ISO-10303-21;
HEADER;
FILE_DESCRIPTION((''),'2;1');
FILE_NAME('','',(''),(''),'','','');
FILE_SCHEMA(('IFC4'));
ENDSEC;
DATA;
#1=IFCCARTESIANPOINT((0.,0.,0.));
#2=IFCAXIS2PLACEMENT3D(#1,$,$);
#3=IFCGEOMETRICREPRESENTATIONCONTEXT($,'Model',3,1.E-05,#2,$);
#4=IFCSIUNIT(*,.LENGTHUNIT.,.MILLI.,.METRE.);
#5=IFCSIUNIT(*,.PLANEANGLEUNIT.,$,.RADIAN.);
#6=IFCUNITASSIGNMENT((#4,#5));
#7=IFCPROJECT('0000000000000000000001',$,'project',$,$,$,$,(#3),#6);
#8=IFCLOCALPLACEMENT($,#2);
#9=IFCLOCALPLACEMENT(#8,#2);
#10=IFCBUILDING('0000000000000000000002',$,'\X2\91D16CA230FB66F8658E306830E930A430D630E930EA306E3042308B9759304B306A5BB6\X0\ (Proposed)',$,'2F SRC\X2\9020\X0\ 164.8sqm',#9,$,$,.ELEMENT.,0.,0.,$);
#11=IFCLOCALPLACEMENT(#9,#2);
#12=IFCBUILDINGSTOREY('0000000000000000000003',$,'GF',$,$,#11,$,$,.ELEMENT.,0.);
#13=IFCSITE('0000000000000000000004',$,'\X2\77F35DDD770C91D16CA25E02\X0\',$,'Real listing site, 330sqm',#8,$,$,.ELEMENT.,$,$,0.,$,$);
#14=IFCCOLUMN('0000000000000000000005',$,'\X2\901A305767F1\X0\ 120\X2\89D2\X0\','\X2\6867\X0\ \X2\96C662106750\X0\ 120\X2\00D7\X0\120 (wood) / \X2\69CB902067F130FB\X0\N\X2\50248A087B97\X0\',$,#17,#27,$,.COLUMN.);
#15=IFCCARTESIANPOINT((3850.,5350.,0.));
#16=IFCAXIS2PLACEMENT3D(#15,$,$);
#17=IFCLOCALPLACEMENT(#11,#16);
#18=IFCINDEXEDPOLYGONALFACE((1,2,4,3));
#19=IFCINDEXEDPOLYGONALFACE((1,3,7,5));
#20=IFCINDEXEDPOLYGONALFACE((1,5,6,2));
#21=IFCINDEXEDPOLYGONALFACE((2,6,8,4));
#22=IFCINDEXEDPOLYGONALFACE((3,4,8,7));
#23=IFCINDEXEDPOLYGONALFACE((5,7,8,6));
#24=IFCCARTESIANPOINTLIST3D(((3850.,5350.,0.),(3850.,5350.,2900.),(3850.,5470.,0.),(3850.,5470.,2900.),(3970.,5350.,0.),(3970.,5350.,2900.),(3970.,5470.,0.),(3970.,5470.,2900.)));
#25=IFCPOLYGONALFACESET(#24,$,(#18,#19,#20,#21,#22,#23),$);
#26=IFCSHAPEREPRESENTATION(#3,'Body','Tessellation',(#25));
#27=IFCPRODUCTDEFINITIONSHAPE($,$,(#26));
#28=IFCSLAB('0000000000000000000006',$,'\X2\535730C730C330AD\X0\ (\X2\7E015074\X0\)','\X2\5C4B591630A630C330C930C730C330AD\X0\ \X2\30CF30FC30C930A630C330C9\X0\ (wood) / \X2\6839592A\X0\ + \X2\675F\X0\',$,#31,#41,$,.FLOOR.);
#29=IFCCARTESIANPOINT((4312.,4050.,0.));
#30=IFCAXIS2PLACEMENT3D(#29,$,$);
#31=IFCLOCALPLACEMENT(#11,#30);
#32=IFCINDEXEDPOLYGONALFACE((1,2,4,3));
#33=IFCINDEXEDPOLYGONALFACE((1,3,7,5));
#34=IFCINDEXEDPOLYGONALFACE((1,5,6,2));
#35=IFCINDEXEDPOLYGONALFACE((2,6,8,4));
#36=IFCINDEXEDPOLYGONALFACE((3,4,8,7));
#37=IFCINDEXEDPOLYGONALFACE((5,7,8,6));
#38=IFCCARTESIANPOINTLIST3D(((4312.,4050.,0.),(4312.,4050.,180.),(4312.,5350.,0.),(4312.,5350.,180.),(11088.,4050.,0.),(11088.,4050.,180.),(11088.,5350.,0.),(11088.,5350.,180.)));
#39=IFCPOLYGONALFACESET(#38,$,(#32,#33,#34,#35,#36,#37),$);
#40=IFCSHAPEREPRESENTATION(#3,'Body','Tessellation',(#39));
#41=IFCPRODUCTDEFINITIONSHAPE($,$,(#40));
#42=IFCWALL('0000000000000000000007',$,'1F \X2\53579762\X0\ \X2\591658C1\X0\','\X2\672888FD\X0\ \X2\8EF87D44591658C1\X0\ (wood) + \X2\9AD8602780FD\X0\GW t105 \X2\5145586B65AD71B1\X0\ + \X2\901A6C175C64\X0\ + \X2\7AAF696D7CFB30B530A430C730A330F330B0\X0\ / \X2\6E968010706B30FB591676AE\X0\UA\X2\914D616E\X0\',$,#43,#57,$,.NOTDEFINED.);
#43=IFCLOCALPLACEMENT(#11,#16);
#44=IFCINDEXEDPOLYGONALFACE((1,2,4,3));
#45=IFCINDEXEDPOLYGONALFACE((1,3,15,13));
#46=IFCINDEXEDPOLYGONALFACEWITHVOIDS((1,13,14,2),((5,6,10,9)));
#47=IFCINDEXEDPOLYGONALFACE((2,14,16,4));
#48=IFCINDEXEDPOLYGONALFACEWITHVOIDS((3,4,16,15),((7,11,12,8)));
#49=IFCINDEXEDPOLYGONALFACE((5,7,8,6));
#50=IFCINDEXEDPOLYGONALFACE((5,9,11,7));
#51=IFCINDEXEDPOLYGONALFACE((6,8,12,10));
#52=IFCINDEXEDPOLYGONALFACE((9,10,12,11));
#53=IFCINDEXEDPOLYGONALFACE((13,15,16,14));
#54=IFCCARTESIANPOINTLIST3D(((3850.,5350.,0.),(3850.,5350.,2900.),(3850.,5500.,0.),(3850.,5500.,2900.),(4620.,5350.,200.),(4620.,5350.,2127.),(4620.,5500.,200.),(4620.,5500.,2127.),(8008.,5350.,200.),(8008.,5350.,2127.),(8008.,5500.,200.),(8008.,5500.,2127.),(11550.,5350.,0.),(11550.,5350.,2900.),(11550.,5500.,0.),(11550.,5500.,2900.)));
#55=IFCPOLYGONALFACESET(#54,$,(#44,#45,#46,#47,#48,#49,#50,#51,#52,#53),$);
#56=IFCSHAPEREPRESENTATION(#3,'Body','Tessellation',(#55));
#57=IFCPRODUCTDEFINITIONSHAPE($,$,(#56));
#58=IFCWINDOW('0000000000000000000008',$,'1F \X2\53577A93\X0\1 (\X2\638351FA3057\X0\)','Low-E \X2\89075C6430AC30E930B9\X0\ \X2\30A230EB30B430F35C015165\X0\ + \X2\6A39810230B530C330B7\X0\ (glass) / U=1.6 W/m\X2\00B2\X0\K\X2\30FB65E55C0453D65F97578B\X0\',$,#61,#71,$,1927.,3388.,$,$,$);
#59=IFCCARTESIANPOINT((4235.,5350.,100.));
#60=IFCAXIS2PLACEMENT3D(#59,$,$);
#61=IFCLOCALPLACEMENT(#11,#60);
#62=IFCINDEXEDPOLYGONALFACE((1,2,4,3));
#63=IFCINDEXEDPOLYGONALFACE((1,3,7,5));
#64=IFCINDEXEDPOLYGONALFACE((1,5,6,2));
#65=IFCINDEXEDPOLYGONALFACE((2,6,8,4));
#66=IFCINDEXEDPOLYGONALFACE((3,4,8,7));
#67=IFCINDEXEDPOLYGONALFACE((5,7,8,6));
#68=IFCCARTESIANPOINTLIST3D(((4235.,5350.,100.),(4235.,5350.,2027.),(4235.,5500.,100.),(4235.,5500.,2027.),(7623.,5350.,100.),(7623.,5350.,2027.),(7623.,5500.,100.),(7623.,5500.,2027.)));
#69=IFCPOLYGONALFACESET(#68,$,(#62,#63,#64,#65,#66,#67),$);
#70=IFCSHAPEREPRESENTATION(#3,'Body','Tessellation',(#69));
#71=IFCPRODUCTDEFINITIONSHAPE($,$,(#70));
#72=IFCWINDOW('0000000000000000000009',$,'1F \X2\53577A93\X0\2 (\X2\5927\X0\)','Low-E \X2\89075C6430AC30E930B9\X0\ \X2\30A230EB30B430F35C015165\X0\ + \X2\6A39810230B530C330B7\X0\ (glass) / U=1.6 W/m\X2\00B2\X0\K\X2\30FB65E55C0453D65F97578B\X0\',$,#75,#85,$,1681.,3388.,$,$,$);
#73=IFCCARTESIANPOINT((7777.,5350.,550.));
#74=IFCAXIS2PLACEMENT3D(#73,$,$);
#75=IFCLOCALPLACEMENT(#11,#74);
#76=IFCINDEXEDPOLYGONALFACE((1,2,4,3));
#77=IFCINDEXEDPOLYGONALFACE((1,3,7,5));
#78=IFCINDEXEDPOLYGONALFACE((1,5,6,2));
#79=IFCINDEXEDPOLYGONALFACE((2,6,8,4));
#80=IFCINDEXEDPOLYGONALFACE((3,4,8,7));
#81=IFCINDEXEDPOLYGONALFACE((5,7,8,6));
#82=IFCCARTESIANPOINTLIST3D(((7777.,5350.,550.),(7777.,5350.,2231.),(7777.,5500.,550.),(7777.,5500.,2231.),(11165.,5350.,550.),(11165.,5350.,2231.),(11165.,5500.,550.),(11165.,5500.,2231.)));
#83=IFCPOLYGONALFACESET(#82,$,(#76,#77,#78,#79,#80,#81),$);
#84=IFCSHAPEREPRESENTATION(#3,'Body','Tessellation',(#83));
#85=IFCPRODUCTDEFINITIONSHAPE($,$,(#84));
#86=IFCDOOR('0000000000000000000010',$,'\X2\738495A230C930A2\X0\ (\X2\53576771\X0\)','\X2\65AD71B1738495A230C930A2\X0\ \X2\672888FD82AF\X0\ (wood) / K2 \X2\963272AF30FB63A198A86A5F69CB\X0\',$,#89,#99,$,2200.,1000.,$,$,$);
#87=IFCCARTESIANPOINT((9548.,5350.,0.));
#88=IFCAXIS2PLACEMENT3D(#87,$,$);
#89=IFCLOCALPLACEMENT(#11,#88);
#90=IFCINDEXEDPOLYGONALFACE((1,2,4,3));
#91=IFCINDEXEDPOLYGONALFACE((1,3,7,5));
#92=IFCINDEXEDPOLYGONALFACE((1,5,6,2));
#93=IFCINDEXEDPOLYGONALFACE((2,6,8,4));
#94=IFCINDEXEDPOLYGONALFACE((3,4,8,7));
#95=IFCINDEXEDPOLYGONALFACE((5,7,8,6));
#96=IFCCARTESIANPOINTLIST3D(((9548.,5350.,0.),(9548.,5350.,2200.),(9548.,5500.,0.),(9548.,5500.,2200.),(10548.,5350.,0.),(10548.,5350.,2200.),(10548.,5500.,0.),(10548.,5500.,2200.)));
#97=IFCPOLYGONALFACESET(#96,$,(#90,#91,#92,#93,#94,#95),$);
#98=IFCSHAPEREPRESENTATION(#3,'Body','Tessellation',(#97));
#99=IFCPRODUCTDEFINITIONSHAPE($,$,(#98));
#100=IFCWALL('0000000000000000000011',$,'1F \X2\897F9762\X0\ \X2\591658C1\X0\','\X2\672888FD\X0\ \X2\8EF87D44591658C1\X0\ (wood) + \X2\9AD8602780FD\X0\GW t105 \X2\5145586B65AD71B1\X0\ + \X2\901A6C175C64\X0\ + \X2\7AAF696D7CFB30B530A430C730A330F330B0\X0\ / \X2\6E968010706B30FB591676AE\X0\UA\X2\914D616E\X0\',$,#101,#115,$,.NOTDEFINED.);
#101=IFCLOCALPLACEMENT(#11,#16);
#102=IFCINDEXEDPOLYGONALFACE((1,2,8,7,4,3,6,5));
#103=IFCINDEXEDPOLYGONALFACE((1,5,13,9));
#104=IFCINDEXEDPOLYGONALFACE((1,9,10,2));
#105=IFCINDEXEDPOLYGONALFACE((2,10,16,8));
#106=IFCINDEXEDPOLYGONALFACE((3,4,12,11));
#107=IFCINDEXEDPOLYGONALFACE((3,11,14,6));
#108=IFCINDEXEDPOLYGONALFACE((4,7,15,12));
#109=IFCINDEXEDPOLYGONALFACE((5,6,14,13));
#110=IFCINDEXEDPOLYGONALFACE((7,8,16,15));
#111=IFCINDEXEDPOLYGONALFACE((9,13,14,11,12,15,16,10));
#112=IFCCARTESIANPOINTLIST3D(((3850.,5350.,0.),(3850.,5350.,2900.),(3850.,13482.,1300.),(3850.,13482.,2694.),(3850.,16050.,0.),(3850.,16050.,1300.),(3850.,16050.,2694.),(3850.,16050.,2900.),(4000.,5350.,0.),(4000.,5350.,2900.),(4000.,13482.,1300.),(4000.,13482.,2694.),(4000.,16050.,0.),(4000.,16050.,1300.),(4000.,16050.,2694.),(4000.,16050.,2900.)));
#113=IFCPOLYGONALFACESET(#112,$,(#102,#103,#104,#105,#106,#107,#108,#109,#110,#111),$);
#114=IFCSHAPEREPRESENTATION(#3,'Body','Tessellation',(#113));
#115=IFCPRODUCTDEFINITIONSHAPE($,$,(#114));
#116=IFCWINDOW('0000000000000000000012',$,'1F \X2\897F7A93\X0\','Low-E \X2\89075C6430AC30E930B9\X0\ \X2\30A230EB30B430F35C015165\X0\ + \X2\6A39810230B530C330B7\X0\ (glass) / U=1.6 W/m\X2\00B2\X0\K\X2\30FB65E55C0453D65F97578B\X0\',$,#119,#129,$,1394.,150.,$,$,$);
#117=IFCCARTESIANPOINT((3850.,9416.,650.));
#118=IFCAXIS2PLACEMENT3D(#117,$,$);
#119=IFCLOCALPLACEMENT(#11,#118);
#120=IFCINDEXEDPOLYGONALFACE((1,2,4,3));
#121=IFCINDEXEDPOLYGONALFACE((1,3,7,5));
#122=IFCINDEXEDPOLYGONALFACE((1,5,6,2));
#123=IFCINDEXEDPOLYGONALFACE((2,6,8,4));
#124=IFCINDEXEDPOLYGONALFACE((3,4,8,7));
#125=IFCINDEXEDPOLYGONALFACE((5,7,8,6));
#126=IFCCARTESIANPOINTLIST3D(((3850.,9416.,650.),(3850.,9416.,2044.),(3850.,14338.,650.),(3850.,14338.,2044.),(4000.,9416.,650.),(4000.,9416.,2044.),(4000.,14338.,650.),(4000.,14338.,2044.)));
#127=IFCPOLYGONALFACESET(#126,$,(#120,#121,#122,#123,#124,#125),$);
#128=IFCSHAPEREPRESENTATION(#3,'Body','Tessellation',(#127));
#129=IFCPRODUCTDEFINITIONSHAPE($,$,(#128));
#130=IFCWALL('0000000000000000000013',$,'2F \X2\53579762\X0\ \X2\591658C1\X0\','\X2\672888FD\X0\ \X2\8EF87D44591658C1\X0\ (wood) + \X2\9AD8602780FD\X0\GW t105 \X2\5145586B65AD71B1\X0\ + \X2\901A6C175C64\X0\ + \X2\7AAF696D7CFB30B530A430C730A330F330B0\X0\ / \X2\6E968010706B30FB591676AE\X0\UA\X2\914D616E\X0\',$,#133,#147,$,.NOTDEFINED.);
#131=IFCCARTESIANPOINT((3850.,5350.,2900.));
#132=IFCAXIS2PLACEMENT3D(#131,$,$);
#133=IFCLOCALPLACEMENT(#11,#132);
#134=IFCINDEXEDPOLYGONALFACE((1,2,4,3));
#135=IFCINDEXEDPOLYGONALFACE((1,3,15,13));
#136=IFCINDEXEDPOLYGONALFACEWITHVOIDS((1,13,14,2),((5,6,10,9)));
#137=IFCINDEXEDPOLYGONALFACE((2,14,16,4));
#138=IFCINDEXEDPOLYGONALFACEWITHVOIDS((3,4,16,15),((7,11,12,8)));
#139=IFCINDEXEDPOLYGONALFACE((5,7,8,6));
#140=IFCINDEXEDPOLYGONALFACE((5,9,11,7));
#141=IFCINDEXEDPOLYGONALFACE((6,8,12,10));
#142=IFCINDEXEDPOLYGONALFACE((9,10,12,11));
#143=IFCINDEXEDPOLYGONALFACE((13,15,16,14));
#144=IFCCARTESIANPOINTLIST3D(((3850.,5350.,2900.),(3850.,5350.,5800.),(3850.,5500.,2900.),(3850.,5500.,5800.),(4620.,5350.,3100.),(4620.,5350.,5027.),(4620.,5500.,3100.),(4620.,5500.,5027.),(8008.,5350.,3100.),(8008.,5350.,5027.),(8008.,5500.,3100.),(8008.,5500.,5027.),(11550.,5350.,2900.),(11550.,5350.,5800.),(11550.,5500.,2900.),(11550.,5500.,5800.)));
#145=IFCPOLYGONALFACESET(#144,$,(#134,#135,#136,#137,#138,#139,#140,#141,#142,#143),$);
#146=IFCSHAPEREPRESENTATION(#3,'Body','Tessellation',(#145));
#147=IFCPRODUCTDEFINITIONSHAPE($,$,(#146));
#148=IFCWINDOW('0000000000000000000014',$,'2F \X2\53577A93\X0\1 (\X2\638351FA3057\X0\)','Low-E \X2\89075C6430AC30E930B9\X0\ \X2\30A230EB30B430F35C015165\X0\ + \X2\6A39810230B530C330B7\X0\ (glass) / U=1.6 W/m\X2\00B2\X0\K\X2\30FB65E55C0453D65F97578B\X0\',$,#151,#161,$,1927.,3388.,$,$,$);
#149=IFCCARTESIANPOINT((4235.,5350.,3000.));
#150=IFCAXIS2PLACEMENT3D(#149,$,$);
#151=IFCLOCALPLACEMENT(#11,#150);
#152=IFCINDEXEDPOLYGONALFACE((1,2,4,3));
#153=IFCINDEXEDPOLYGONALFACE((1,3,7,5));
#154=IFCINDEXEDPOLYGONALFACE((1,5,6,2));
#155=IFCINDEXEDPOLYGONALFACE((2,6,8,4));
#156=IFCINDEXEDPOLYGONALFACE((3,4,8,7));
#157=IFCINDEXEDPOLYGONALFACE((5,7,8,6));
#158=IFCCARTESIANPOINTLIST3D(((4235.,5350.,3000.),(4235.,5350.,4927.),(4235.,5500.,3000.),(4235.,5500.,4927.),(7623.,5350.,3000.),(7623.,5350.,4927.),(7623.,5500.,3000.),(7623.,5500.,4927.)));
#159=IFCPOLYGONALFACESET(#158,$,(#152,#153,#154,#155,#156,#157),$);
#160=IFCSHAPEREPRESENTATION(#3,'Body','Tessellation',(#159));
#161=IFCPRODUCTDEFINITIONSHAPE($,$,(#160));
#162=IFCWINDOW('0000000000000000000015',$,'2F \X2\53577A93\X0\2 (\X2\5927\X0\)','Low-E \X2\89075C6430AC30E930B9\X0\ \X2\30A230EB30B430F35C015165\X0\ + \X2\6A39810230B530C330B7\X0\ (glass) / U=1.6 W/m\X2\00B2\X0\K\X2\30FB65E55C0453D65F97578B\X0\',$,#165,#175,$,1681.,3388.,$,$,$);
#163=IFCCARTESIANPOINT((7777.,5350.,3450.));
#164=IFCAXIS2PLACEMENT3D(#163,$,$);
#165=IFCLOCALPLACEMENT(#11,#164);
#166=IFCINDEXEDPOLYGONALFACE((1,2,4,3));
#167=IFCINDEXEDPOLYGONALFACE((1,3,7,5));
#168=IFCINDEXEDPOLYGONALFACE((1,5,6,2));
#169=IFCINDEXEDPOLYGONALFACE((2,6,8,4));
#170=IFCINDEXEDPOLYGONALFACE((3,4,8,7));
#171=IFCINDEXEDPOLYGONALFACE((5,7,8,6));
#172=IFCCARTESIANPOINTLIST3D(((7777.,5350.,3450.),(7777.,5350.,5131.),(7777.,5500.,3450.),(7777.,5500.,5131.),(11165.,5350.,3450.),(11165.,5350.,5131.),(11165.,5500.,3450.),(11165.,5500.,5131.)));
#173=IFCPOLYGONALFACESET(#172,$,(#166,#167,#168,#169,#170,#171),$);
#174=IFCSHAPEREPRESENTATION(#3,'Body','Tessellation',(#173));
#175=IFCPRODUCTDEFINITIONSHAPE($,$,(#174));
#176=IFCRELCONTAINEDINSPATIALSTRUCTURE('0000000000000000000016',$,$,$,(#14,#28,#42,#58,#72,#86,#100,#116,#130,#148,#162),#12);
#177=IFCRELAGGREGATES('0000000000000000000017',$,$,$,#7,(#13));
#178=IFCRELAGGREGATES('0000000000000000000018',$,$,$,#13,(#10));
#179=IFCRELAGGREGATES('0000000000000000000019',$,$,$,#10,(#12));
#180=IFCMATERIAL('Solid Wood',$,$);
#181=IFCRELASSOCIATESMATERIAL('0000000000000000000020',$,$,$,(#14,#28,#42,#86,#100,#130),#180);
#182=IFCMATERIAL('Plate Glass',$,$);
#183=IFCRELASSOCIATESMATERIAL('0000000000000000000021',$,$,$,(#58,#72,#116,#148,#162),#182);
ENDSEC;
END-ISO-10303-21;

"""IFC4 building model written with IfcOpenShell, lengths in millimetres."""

from ifc_helpers import new_model, si_unit, frame, frame_2d, origin, place, context, project, spatial, rectangle, extrude, material, element, fill, save


model = new_model("IFC4")

# Units and contexts
model_context = context("Model", 3, precision=1e-05, world=origin())
ifc_project = project(units=[si_unit("LENGTHUNIT", "METRE", prefix="MILLI"), si_unit("PLANEANGLEUNIT", "RADIAN")], contexts=[model_context])

# Site, building, storey
site_placement = place(None, origin())
site = spatial("IfcSite", under=ifc_project, at=site_placement, Name="石川県金沢市", ObjectType="Real listing site, 330sqm", CompositionType="ELEMENT", RefElevation=0.0)
building_placement = place(site_placement, origin())
building = spatial("IfcBuilding", under=site, at=building_placement, Name="金沢・書斎とライブラリのある静かな家 (Proposed)", ObjectType="2F SRC造 164.8sqm", CompositionType="ELEMENT", ElevationOfRefHeight=0.0, ElevationOfTerrain=0.0)
storey_placement = place(building_placement, origin())
storey = spatial("IfcBuildingStorey", under=building, at=storey_placement, Name="GF", CompositionType="ELEMENT", Elevation=0.0)

# Column
ifc_material_1 = material(Name="Solid Wood")
column_placement = place(storey_placement, frame((3850.0, 5350.0, 0.0)))
element("IfcColumn", 1, at=column_placement, inside=storey, material=ifc_material_1, Name="通し柱 120角", Description="桧 集成材 120×120 (wood) / 構造柱・N値計算", PredefinedType="COLUMN", context=model_context, shape_type="SweptSolid", body=[
    extrude(rectangle(XDim=120.0, YDim=120.0, at=frame_2d((60.0, 60.0))), frame((3850.0, 5350.0, 0.0)), (0.0, 0.0, 1.0), 2900.0),
])

# Slab
slab_1_placement = place(storey_placement, frame((4312.0, 4050.0, 0.0)))
element("IfcSlab", 2, at=slab_1_placement, inside=storey, material=ifc_material_1, Name="南デッキ (縁側)", Description="屋外ウッドデッキ ハードウッド (wood) / 根太 + 束", PredefinedType="FLOOR", context=model_context, shape_type="SweptSolid", body=[
    extrude(rectangle(XDim=6776.0, YDim=1300.0, at=frame_2d((3388.0, 650.0))), frame((4312.0, 4050.0, 0.0)), (0.0, 0.0, 1.0), 180.0),
])

# Wall, openings, windows, door
wall_1_placement = place(storey_placement, frame((3850.0, 5350.0, 0.0)))
wall_1 = element("IfcWall", 3, at=wall_1_placement, inside=storey, material=ifc_material_1, Name="1F 南面 外壁", Description="木製 軸組外壁 (wood) + 高性能GW t105 充填断熱 + 通気層 + 窯業系サイディング / 準耐火・外皮UA配慮", PredefinedType="NOTDEFINED", context=model_context, shape_type="SweptSolid", body=[
    extrude(rectangle(XDim=7700.0, YDim=150.0, at=frame_2d((3850.0, 75.0))), frame((3850.0, 5350.0, 0.0)), (0.0, 0.0, 1.0), 2900.0),
])
opening_1_placement = place(storey_placement, frame((4235.0, 5350.0, 100.0)))
opening_1 = element("IfcOpeningElement", 4, at=opening_1_placement, cuts=wall_1, PredefinedType="NOTDEFINED", context=model_context, shape_type="SweptSolid", body=[
    extrude(rectangle(XDim=3388.0, YDim=150.0, at=frame_2d((1694.0, 75.0))), frame((4235.0, 5350.0, 100.0)), (0.0, 0.0, 1.0), 1927.0),
])
opening_2_placement = place(storey_placement, frame((7777.0, 5350.0, 550.0)))
opening_2 = element("IfcOpeningElement", 5, at=opening_2_placement, cuts=wall_1, PredefinedType="NOTDEFINED", context=model_context, shape_type="SweptSolid", body=[
    extrude(rectangle(XDim=3388.0, YDim=150.0, at=frame_2d((1694.0, 75.0))), frame((7777.0, 5350.0, 550.0)), (0.0, 0.0, 1.0), 1681.0),
])
opening_3_placement = place(storey_placement, frame((9548.0, 5350.0, 0.0)))
opening_3 = element("IfcOpeningElement", 6, at=opening_3_placement, cuts=wall_1, PredefinedType="NOTDEFINED", context=model_context, shape_type="SweptSolid", body=[
    extrude(rectangle(XDim=1000.0, YDim=150.0, at=frame_2d((500.0, 75.0))), frame((9548.0, 5350.0, 0.0)), (0.0, 0.0, 1.0), 2200.0),
])
ifc_material_2 = material(Name="Plate Glass")
window_1_placement = place(storey_placement, frame((4235.0, 5350.0, 100.0)))
window_1 = element("IfcWindow", 7, at=window_1_placement, inside=storey, material=ifc_material_2, Name="1F 南窓1 (掃出し)", Description="Low-E 複層ガラス アルゴン封入 + 樹脂サッシ (glass) / U=1.6 W/m²K・日射取得型", OverallHeight=1927.0, OverallWidth=3388.0, context=model_context, shape_type="SweptSolid", body=[
    extrude(rectangle(XDim=3388.0, YDim=150.0, at=frame_2d((1694.0, 75.0))), frame((4235.0, 5350.0, 100.0)), (0.0, 0.0, 1.0), 1927.0),
])
fill(opening_1, window_1)
window_2_placement = place(storey_placement, frame((7777.0, 5350.0, 550.0)))
window_2 = element("IfcWindow", 8, at=window_2_placement, inside=storey, material=ifc_material_2, Name="1F 南窓2 (大)", Description="Low-E 複層ガラス アルゴン封入 + 樹脂サッシ (glass) / U=1.6 W/m²K・日射取得型", OverallHeight=1681.0, OverallWidth=3388.0, context=model_context, shape_type="SweptSolid", body=[
    extrude(rectangle(XDim=3388.0, YDim=150.0, at=frame_2d((1694.0, 75.0))), frame((7777.0, 5350.0, 550.0)), (0.0, 0.0, 1.0), 1681.0),
])
fill(opening_2, window_2)
door_placement = place(storey_placement, frame((9548.0, 5350.0, 0.0)))
door = element("IfcDoor", 9, at=door_placement, inside=storey, material=ifc_material_1, Name="玄関ドア (南東)", Description="断熱玄関ドア 木製芯 (wood) / K2 防犯・採風機構", OverallHeight=2200.0, OverallWidth=1000.0, context=model_context, shape_type="SweptSolid", body=[
    extrude(rectangle(XDim=1000.0, YDim=150.0, at=frame_2d((500.0, 75.0))), frame((9548.0, 5350.0, 0.0)), (0.0, 0.0, 1.0), 2200.0),
])
fill(opening_3, door)

# Wall, opening, window
wall_2_placement = place(storey_placement, frame((3850.0, 5350.0, 0.0)))
wall_2 = element("IfcWall", 10, at=wall_2_placement, inside=storey, material=ifc_material_1, Name="1F 西面 外壁", Description="木製 軸組外壁 (wood) + 高性能GW t105 充填断熱 + 通気層 + 窯業系サイディング / 準耐火・外皮UA配慮", PredefinedType="NOTDEFINED", context=model_context, shape_type="SweptSolid", body=[
    extrude(rectangle(XDim=150.0, YDim=10700.0, at=frame_2d((75.0, 5350.0))), frame((3850.0, 5350.0, 0.0)), (0.0, 0.0, 1.0), 2900.0),
])
opening_4_placement = place(storey_placement, frame((3850.0, 9416.0, 650.0)))
opening_4 = element("IfcOpeningElement", 11, at=opening_4_placement, cuts=wall_2, PredefinedType="NOTDEFINED", context=model_context, shape_type="SweptSolid", body=[
    extrude(rectangle(XDim=150.0, YDim=4922.0, at=frame_2d((75.0, 2461.0))), frame((3850.0, 9416.0, 650.0)), (0.0, 0.0, 1.0), 1394.0),
])
window_3_placement = place(storey_placement, frame((3850.0, 9416.0, 650.0)))
window_3 = element("IfcWindow", 12, at=window_3_placement, inside=storey, material=ifc_material_2, Name="1F 西窓", Description="Low-E 複層ガラス アルゴン封入 + 樹脂サッシ (glass) / U=1.6 W/m²K・日射取得型", OverallHeight=1394.0, OverallWidth=150.0, context=model_context, shape_type="SweptSolid", body=[
    extrude(rectangle(XDim=150.0, YDim=4922.0, at=frame_2d((75.0, 2461.0))), frame((3850.0, 9416.0, 650.0)), (0.0, 0.0, 1.0), 1394.0),
])
fill(opening_4, window_3)

# Wall, openings, windows
wall_3_placement = place(storey_placement, frame((3850.0, 5350.0, 2900.0)))
wall_3 = element("IfcWall", 13, at=wall_3_placement, inside=storey, material=ifc_material_1, Name="2F 南面 外壁", Description="木製 軸組外壁 (wood) + 高性能GW t105 充填断熱 + 通気層 + 窯業系サイディング / 準耐火・外皮UA配慮", PredefinedType="NOTDEFINED", context=model_context, shape_type="SweptSolid", body=[
    extrude(rectangle(XDim=7700.0, YDim=150.0, at=frame_2d((3850.0, 75.0))), frame((3850.0, 5350.0, 2900.0)), (0.0, 0.0, 1.0), 2900.0),
])
opening_5_placement = place(storey_placement, frame((4235.0, 5350.0, 3000.0)))
opening_5 = element("IfcOpeningElement", 14, at=opening_5_placement, cuts=wall_3, PredefinedType="NOTDEFINED", context=model_context, shape_type="SweptSolid", body=[
    extrude(rectangle(XDim=3388.0, YDim=150.0, at=frame_2d((1694.0, 75.0))), frame((4235.0, 5350.0, 3000.0)), (0.0, 0.0, 1.0), 1927.0),
])
opening_6_placement = place(storey_placement, frame((7777.0, 5350.0, 3450.0)))
opening_6 = element("IfcOpeningElement", 15, at=opening_6_placement, cuts=wall_3, PredefinedType="NOTDEFINED", context=model_context, shape_type="SweptSolid", body=[
    extrude(rectangle(XDim=3388.0, YDim=150.0, at=frame_2d((1694.0, 75.0))), frame((7777.0, 5350.0, 3450.0)), (0.0, 0.0, 1.0), 1681.0),
])
window_4_placement = place(storey_placement, frame((4235.0, 5350.0, 3000.0)))
window_4 = element("IfcWindow", 16, at=window_4_placement, inside=storey, material=ifc_material_2, Name="2F 南窓1 (掃出し)", Description="Low-E 複層ガラス アルゴン封入 + 樹脂サッシ (glass) / U=1.6 W/m²K・日射取得型", OverallHeight=1927.0, OverallWidth=3388.0, context=model_context, shape_type="SweptSolid", body=[
    extrude(rectangle(XDim=3388.0, YDim=150.0, at=frame_2d((1694.0, 75.0))), frame((4235.0, 5350.0, 3000.0)), (0.0, 0.0, 1.0), 1927.0),
])
fill(opening_5, window_4)
window_5_placement = place(storey_placement, frame((7777.0, 5350.0, 3450.0)))
window_5 = element("IfcWindow", 17, at=window_5_placement, inside=storey, material=ifc_material_2, Name="2F 南窓2 (大)", Description="Low-E 複層ガラス アルゴン封入 + 樹脂サッシ (glass) / U=1.6 W/m²K・日射取得型", OverallHeight=1681.0, OverallWidth=3388.0, context=model_context, shape_type="SweptSolid", body=[
    extrude(rectangle(XDim=3388.0, YDim=150.0, at=frame_2d((1694.0, 75.0))), frame((7777.0, 5350.0, 3450.0)), (0.0, 0.0, 1.0), 1681.0),
])
fill(opening_6, window_5)

save(model, "model.ifc")
